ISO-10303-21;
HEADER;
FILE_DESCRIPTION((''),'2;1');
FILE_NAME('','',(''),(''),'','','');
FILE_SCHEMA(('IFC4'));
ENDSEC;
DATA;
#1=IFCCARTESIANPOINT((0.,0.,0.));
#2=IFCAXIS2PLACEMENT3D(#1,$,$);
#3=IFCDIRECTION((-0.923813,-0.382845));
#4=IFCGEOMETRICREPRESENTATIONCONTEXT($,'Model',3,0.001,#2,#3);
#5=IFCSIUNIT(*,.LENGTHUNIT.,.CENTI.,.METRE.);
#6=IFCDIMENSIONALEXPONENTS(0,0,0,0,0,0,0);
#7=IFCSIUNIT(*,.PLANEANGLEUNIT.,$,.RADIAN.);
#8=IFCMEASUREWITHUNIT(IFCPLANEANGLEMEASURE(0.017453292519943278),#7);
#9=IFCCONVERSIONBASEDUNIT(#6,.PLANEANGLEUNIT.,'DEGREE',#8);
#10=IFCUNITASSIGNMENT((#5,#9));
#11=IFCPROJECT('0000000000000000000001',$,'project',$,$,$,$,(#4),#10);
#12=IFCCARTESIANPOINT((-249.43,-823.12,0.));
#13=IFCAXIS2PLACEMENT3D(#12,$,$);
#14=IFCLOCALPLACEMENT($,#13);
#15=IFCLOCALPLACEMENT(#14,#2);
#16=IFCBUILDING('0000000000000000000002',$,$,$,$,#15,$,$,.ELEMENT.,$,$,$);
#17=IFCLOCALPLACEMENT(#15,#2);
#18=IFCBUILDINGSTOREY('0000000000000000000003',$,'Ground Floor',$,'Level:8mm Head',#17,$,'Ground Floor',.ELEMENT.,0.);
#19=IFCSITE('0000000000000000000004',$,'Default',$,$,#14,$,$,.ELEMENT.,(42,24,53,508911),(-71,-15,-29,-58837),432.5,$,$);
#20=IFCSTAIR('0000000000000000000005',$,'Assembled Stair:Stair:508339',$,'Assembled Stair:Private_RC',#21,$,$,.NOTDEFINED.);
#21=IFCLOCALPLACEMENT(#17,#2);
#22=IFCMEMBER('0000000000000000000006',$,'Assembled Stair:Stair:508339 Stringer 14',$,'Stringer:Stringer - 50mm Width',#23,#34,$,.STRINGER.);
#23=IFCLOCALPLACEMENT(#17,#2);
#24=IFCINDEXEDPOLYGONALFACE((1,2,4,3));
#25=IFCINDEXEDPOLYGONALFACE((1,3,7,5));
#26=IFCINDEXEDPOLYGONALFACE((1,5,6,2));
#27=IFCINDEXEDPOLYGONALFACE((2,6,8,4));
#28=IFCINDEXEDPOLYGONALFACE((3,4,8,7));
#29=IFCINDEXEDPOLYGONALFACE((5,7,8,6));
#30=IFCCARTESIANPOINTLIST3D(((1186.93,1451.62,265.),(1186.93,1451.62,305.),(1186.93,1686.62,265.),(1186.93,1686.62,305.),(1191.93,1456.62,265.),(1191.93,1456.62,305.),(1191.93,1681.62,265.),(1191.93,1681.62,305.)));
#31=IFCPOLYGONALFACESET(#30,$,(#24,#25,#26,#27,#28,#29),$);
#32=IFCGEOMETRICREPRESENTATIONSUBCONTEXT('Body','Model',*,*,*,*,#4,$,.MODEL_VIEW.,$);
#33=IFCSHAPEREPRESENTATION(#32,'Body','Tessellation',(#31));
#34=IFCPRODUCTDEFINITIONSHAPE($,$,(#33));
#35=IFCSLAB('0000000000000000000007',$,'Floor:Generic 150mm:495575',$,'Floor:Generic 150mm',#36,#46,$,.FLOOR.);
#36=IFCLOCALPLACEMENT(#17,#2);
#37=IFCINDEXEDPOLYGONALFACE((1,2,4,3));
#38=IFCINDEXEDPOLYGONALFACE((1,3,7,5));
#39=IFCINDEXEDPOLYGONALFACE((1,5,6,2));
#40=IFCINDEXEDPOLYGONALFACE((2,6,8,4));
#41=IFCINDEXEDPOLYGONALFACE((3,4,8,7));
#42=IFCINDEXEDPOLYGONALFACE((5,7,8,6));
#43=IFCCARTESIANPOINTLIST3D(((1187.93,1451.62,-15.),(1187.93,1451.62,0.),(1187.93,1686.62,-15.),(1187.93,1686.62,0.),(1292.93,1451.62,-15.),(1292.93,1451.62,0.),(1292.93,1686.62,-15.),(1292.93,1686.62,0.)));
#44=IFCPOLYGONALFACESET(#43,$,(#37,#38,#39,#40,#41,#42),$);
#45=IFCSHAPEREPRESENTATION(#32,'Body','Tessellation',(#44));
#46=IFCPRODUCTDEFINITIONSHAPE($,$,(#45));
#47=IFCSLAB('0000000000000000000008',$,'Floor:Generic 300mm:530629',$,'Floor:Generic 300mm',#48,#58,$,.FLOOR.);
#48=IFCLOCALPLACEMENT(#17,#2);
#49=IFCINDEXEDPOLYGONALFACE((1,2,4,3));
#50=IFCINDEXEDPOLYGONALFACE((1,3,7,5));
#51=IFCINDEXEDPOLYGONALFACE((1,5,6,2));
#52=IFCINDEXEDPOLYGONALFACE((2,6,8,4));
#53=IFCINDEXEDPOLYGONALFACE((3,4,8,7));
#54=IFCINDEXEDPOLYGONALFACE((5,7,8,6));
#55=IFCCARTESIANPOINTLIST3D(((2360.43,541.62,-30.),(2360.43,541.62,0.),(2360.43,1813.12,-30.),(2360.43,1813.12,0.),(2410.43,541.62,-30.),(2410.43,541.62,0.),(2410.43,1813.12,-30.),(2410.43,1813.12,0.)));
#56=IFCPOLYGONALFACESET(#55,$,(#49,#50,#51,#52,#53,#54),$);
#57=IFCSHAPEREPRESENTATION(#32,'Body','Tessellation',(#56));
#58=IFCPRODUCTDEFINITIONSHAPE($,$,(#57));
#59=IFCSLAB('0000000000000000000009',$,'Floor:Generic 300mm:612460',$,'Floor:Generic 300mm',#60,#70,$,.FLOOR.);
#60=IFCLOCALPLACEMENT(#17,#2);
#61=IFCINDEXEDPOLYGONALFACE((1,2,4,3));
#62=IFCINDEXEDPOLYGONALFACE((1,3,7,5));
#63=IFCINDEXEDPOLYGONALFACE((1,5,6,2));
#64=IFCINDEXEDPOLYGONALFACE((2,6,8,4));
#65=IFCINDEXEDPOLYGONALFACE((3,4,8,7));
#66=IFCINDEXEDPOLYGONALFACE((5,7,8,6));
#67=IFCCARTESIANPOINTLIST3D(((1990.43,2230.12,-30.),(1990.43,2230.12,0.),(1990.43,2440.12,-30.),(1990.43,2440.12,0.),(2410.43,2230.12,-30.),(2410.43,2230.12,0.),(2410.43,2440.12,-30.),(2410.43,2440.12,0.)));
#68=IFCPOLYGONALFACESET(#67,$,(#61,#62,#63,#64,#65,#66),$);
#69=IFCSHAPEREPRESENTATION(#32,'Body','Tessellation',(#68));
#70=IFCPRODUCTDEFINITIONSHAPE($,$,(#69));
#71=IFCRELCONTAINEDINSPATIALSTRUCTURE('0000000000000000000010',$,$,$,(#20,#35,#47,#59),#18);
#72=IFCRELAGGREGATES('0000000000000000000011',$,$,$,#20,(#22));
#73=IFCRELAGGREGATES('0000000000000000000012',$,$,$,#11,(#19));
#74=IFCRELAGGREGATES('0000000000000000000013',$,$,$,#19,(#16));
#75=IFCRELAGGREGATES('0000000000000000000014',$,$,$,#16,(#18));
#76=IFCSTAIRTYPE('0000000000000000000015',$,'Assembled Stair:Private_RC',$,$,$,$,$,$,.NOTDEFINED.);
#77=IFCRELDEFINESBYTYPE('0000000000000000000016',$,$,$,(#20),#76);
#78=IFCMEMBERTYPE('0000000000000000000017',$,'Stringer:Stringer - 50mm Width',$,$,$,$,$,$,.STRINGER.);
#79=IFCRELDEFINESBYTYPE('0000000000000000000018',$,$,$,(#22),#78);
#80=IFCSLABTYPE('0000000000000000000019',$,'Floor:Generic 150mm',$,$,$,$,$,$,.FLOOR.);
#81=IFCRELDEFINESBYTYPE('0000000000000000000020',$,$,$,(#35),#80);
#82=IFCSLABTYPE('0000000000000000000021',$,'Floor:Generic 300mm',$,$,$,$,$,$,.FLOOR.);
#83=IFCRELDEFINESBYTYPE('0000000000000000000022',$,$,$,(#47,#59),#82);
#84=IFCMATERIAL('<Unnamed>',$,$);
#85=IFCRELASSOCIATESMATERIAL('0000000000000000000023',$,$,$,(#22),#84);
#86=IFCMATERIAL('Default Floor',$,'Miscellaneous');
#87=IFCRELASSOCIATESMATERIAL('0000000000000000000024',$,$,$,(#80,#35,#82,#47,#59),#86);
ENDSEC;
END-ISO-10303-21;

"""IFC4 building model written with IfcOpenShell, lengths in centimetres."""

from ifc_helpers import new_model, entity, si_unit, converted_unit, direction, frame, origin, place, context, subcontext, project, spatial, indexed_curve, outline, extrude, material, type_object, element, aggregate, save


model = new_model("IFC4")

# Units and contexts
model_context = context("Model", 3, precision=0.001, world=origin(), true_north=direction((-0.923813, -0.382845)))
body_context = subcontext(model_context, "Body", "Model", "MODEL_VIEW")
ifc_project = project(units=[si_unit("LENGTHUNIT", "METRE", prefix="CENTI"), converted_unit("PLANEANGLEUNIT", "DEGREE", entity("IfcPlaneAngleMeasure", 0.017453292519943278), si_unit("PLANEANGLEUNIT", "RADIAN"), dimensions=[0, 0, 0, 0, 0, 0, 0])], contexts=[model_context])

# Site, building, storey
site_placement = place(None, frame((-249.43, -823.12, 0.0)))
site = spatial("IfcSite", under=ifc_project, at=site_placement, Name="Default", CompositionType="ELEMENT", RefLatitude=(42, 24, 53, 508911), RefLongitude=(-71, -15, -29, -58837), RefElevation=432.5)
building_placement = place(site_placement, origin())
building = spatial("IfcBuilding", under=site, at=building_placement, CompositionType="ELEMENT")
storey_placement = place(building_placement, origin())
storey = spatial("IfcBuildingStorey", under=building, at=storey_placement, Name="Ground Floor", ObjectType="Level:8mm Head", LongName="Ground Floor", CompositionType="ELEMENT", Elevation=0.0)

# Stair, member
stair_type = type_object("IfcStairType", Name="Assembled Stair:Private_RC", PredefinedType="NOTDEFINED")
stair_placement = place(storey_placement, origin())
stair = element("IfcStair", 1, at=stair_placement, inside=storey, type_object=stair_type, Name="Assembled Stair:Stair:508339", ObjectType="Assembled Stair:Private_RC", PredefinedType="NOTDEFINED")
ifc_material_1 = material(Name="<Unnamed>")
member_type = type_object("IfcMemberType", Name="Stringer:Stringer - 50mm Width", PredefinedType="STRINGER")
member_1_placement = place(stair_placement, origin())
member_1 = element("IfcMember", 2, at=member_1_placement, type_object=member_type, material=ifc_material_1, Name="Assembled Stair:Stair:508339 Stringer 14", ObjectType="Stringer:Stringer - 50mm Width", PredefinedType="STRINGER", context=body_context, shape_type="SweptSolid", body=[
    extrude(outline(indexed_curve([(-117.5, -2.5), (117.5, -2.5), (112.5, 2.5), (-112.5, 2.5), (-117.5, -2.5)], self_intersect=False)), frame((1189.43, 1569.12, 265.0), z_axis=(0.0, 0.0, 1.0), x_axis=(0.0, -1.0, 0.0)), (0.0, 0.0, 1.0), 40.0),
])

# Slabs
ifc_material_2 = material(Name="Default Floor", Category="Miscellaneous")
slab_type_1 = type_object("IfcSlabType", Name="Floor:Generic 150mm", PredefinedType="FLOOR", material=ifc_material_2)
slab_1_placement = place(storey_placement, origin())
element("IfcSlab", 3, at=slab_1_placement, inside=storey, type_object=slab_type_1, material=ifc_material_2, Name="Floor:Generic 150mm:495575", ObjectType="Floor:Generic 150mm", PredefinedType="FLOOR", context=body_context, shape_type="SweptSolid", body=[
    extrude(outline(indexed_curve([(-117.5, -52.5), (117.5, -52.5), (117.5, 52.5), (-117.5, 52.5), (-117.5, -52.5)], self_intersect=False)), frame((1240.43, 1569.12, 0.0), z_axis=(0.0, 0.0, -1.0), x_axis=(0.0, 1.0, 0.0)), (0.0, 0.0, 1.0), 15.0),
])
slab_type_2 = type_object("IfcSlabType", Name="Floor:Generic 300mm", PredefinedType="FLOOR", material=ifc_material_2)
slab_2_placement = place(storey_placement, origin())
element("IfcSlab", 4, at=slab_2_placement, inside=storey, type_object=slab_type_2, material=ifc_material_2, Name="Floor:Generic 300mm:530629", ObjectType="Floor:Generic 300mm", PredefinedType="FLOOR", context=body_context, shape_type="SweptSolid", body=[
    extrude(outline(indexed_curve([(-25.0, -635.75), (25.0, -635.75), (25.0, 635.75), (-25.0, 635.75), (-25.0, -635.75)], self_intersect=False)), frame((2385.43, 1177.37, 0.0), z_axis=(0.0, 0.0, -1.0), x_axis=(1.0, 0.0, 0.0)), (0.0, 0.0, 1.0), 30.0),
])
slab_3_placement = place(storey_placement, origin())
element("IfcSlab", 5, at=slab_3_placement, inside=storey, type_object=slab_type_2, material=ifc_material_2, Name="Floor:Generic 300mm:612460", ObjectType="Floor:Generic 300mm", PredefinedType="FLOOR", context=body_context, shape_type="SweptSolid", body=[
    extrude(outline(indexed_curve([(-105.0, -210.0), (105.0, -210.0), (105.0, 210.0), (-105.0, 210.0), (-105.0, -210.0)], self_intersect=False)), frame((2200.43, 2335.12, 0.0), z_axis=(0.0, 0.0, -1.0), x_axis=(0.0, 1.0, 0.0)), (0.0, 0.0, 1.0), 30.0),
])

aggregate(stair, [member_1])

save(model, "model.ifc")
